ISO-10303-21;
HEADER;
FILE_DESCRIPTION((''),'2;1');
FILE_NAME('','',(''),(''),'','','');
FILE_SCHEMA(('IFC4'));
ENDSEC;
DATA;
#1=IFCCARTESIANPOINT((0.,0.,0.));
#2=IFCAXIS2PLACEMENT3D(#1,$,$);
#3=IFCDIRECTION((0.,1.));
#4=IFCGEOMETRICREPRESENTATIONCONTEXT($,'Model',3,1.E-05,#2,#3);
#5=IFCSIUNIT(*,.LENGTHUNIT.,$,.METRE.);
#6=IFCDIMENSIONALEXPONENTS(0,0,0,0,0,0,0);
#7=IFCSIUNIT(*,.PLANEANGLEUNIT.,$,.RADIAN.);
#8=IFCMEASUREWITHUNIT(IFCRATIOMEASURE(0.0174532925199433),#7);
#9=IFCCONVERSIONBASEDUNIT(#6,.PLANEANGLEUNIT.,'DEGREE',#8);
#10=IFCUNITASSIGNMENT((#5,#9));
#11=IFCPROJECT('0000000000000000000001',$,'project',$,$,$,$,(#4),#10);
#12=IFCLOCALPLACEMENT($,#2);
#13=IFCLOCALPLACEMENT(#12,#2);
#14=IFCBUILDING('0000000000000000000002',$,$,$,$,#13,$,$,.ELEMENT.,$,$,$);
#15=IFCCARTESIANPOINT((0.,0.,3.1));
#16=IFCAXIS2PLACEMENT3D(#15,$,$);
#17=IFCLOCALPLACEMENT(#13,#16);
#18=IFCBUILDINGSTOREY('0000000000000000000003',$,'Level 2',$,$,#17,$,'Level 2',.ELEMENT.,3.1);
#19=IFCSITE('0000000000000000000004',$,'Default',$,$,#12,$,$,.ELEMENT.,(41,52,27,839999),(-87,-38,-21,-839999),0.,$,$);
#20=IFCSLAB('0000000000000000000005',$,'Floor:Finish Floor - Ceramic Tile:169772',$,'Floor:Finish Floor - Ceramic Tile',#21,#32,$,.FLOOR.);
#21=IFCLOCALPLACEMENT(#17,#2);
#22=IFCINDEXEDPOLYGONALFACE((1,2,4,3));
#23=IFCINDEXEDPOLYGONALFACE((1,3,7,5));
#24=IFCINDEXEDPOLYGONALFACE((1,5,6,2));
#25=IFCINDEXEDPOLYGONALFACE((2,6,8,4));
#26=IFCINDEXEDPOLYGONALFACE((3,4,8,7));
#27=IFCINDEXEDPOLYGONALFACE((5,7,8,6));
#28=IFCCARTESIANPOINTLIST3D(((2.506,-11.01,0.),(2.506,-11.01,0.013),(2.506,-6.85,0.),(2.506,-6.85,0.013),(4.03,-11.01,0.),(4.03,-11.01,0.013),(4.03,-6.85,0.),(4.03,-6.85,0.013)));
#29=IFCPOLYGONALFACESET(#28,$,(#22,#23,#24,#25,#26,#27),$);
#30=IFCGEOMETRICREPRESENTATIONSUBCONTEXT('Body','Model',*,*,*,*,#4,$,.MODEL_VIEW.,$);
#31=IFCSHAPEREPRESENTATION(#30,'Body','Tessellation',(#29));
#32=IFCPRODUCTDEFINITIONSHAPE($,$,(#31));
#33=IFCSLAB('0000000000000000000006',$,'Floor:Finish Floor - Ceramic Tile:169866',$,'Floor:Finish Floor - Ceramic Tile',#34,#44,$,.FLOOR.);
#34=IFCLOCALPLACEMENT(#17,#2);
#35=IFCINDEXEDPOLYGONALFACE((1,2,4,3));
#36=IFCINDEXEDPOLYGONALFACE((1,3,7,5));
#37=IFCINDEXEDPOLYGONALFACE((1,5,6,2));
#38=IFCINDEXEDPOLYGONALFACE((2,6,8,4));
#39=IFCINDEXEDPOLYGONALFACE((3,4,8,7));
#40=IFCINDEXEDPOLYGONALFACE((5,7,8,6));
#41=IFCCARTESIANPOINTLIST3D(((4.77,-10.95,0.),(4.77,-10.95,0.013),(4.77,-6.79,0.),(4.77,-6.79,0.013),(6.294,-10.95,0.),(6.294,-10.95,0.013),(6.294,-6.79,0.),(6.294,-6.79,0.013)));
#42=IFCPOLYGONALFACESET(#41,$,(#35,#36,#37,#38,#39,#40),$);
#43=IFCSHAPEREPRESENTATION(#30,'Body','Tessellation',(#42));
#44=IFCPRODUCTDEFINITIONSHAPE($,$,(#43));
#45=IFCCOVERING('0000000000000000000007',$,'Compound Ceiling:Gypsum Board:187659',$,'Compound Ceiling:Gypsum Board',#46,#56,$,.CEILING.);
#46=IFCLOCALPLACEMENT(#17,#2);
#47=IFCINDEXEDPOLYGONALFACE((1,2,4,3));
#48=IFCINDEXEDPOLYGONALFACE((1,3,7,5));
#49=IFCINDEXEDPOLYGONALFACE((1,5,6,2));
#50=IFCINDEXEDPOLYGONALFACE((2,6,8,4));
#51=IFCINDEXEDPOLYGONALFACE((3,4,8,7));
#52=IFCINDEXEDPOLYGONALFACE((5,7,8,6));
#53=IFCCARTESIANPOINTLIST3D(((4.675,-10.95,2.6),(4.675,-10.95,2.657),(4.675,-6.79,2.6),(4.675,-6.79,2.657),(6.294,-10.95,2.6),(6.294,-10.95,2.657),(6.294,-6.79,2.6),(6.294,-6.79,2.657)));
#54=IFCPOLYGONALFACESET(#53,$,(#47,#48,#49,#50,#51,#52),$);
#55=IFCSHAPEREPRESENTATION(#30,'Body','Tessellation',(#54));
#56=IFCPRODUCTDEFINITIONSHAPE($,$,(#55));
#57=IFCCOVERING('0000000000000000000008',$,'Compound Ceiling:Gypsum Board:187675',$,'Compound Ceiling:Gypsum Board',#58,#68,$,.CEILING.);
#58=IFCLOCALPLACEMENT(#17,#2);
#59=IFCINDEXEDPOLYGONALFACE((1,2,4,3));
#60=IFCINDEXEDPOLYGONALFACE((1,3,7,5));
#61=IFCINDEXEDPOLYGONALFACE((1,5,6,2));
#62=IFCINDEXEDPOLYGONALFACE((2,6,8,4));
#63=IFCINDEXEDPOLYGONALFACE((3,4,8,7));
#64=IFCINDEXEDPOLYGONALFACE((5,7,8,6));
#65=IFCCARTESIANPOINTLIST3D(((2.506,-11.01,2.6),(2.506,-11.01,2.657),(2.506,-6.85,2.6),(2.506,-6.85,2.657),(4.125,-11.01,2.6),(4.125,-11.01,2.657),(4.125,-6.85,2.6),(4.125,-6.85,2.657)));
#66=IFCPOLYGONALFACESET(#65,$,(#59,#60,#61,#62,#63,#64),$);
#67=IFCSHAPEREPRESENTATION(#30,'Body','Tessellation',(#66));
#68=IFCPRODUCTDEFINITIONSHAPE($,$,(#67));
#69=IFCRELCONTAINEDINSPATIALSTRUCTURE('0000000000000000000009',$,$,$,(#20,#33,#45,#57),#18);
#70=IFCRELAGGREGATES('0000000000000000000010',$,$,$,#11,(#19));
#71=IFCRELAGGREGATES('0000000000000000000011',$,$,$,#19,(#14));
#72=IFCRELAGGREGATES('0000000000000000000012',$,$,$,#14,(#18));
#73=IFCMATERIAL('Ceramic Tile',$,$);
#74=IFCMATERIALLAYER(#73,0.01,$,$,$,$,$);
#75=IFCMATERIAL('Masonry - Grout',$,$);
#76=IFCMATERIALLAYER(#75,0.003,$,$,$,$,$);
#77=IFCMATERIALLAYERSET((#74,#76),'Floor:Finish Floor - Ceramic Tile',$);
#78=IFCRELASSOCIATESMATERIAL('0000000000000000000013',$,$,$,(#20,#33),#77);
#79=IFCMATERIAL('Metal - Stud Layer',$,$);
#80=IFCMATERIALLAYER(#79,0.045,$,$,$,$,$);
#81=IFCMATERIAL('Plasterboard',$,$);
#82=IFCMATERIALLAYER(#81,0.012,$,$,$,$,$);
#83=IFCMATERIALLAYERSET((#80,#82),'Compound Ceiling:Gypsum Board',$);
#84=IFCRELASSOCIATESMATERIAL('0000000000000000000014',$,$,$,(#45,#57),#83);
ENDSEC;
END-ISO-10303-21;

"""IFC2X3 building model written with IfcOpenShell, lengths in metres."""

from ifc_helpers import new_model, entity, si_unit, converted_unit, direction, frame, frame_2d, origin, place, context, subcontext, project, spatial, rectangle, extrude, material, layer, layer_set, layer_usage, element, save


model = new_model("IFC2X3")

# Units and contexts
model_context = context("Model", 3, precision=1e-05, world=origin(), true_north=direction((0.0, 1.0)))
body_context = subcontext(model_context, "Body", "Model", "MODEL_VIEW")
ifc_project = project(units=[si_unit("LENGTHUNIT", "METRE"), converted_unit("PLANEANGLEUNIT", "DEGREE", entity("IfcRatioMeasure", 0.0174532925199433), si_unit("PLANEANGLEUNIT", "RADIAN"), dimensions=[0, 0, 0, 0, 0, 0, 0])], contexts=[model_context])

# Site, building, storey
site_placement = place(None, origin())
site = spatial("IfcSite", under=ifc_project, at=site_placement, Name="Default", CompositionType="ELEMENT", RefLatitude=(41, 52, 27, 839999), RefLongitude=(-87, -38, -21, -839999), RefElevation=0.0)
building_placement = place(site_placement, origin())
building = spatial("IfcBuilding", under=site, at=building_placement, CompositionType="ELEMENT")
storey_placement = place(building_placement, frame((0.0, 0.0, 3.1)))
storey = spatial("IfcBuildingStorey", under=building, at=storey_placement, Name="Level 2", LongName="Level 2", CompositionType="ELEMENT", Elevation=3.1)

# Slabs
ifc_material_1 = material(Name="Ceramic Tile")
ifc_layer_1 = layer(ifc_material_1, 0.01)
ifc_material_2 = material(Name="Masonry - Grout")
ifc_layer_2 = layer(ifc_material_2, 0.003)
ifc_layer_set_1 = layer_set([ifc_layer_1, ifc_layer_2], Name="Floor:Finish Floor - Ceramic Tile")
ifc_layer_usage_1 = layer_usage(ifc_layer_set_1, "AXIS3", "POSITIVE", 0.0)
slab_1_placement = place(storey_placement, origin())
element("IfcSlab", 1, at=slab_1_placement, inside=storey, material=ifc_layer_usage_1, Name="Floor:Finish Floor - Ceramic Tile:169772", ObjectType="Floor:Finish Floor - Ceramic Tile", PredefinedType="FLOOR", context=body_context, shape_type="SweptSolid", body=[
    extrude(rectangle(XDim=4.16, YDim=1.524, at=frame_2d((0.0, 0.0), x_axis=(1.0, 0.0))), frame((3.268, -8.93, 0.013), z_axis=(0.0, 0.0, -1.0), x_axis=(0.0, 1.0, 0.0)), (0.0, 0.0, 1.0), 0.013),
])
ifc_layer_usage_2 = layer_usage(ifc_layer_set_1, "AXIS3", "POSITIVE", 0.0)
slab_2_placement = place(storey_placement, origin())
element("IfcSlab", 2, at=slab_2_placement, inside=storey, material=ifc_layer_usage_2, Name="Floor:Finish Floor - Ceramic Tile:169866", ObjectType="Floor:Finish Floor - Ceramic Tile", PredefinedType="FLOOR", context=body_context, shape_type="SweptSolid", body=[
    extrude(rectangle(XDim=4.16, YDim=1.524, at=frame_2d((0.0, 0.0), x_axis=(1.0, 0.0))), frame((5.532, -8.87, 0.013), z_axis=(0.0, 0.0, -1.0), x_axis=(0.0, 1.0, 0.0)), (0.0, 0.0, 1.0), 0.013),
])

# Shared definitions
ifc_material_3 = material(Name="Metal - Stud Layer")
ifc_material_4 = material(Name="Plasterboard")

# Shared definitions
ifc_layer_3 = layer(ifc_material_3, 0.045)
ifc_layer_4 = layer(ifc_material_4, 0.012)
ifc_layer_set_2 = layer_set([ifc_layer_3, ifc_layer_4], Name="Compound Ceiling:Gypsum Board")

# Coverings
ifc_layer_usage_3 = layer_usage(ifc_layer_set_2, "AXIS3", "POSITIVE", 0.0)
covering_1_placement = place(storey_placement, origin())
element("IfcCovering", 3, at=covering_1_placement, inside=storey, material=ifc_layer_usage_3, Name="Compound Ceiling:Gypsum Board:187659", ObjectType="Compound Ceiling:Gypsum Board", PredefinedType="CEILING", context=body_context, shape_type="SweptSolid", body=[
    extrude(rectangle(XDim=1.619, YDim=4.16, at=frame_2d((0.0, 0.0), x_axis=(1.0, 0.0))), frame((5.4845, -8.87, 2.6)), (0.0, 0.0, 1.0), 0.057),
])
ifc_layer_usage_4 = layer_usage(ifc_layer_set_2, "AXIS3", "POSITIVE", 0.0)
covering_2_placement = place(storey_placement, origin())
element("IfcCovering", 4, at=covering_2_placement, inside=storey, material=ifc_layer_usage_4, Name="Compound Ceiling:Gypsum Board:187675", ObjectType="Compound Ceiling:Gypsum Board", PredefinedType="CEILING", context=body_context, shape_type="SweptSolid", body=[
    extrude(rectangle(XDim=1.619, YDim=4.16, at=frame_2d((0.0, 0.0), x_axis=(1.0, 0.0))), frame((3.3155, -8.93, 2.6), z_axis=(0.0, 0.0, 1.0), x_axis=(-1.0, 0.0, 0.0)), (0.0, 0.0, 1.0), 0.057),
])

save(model, "model.ifc")
